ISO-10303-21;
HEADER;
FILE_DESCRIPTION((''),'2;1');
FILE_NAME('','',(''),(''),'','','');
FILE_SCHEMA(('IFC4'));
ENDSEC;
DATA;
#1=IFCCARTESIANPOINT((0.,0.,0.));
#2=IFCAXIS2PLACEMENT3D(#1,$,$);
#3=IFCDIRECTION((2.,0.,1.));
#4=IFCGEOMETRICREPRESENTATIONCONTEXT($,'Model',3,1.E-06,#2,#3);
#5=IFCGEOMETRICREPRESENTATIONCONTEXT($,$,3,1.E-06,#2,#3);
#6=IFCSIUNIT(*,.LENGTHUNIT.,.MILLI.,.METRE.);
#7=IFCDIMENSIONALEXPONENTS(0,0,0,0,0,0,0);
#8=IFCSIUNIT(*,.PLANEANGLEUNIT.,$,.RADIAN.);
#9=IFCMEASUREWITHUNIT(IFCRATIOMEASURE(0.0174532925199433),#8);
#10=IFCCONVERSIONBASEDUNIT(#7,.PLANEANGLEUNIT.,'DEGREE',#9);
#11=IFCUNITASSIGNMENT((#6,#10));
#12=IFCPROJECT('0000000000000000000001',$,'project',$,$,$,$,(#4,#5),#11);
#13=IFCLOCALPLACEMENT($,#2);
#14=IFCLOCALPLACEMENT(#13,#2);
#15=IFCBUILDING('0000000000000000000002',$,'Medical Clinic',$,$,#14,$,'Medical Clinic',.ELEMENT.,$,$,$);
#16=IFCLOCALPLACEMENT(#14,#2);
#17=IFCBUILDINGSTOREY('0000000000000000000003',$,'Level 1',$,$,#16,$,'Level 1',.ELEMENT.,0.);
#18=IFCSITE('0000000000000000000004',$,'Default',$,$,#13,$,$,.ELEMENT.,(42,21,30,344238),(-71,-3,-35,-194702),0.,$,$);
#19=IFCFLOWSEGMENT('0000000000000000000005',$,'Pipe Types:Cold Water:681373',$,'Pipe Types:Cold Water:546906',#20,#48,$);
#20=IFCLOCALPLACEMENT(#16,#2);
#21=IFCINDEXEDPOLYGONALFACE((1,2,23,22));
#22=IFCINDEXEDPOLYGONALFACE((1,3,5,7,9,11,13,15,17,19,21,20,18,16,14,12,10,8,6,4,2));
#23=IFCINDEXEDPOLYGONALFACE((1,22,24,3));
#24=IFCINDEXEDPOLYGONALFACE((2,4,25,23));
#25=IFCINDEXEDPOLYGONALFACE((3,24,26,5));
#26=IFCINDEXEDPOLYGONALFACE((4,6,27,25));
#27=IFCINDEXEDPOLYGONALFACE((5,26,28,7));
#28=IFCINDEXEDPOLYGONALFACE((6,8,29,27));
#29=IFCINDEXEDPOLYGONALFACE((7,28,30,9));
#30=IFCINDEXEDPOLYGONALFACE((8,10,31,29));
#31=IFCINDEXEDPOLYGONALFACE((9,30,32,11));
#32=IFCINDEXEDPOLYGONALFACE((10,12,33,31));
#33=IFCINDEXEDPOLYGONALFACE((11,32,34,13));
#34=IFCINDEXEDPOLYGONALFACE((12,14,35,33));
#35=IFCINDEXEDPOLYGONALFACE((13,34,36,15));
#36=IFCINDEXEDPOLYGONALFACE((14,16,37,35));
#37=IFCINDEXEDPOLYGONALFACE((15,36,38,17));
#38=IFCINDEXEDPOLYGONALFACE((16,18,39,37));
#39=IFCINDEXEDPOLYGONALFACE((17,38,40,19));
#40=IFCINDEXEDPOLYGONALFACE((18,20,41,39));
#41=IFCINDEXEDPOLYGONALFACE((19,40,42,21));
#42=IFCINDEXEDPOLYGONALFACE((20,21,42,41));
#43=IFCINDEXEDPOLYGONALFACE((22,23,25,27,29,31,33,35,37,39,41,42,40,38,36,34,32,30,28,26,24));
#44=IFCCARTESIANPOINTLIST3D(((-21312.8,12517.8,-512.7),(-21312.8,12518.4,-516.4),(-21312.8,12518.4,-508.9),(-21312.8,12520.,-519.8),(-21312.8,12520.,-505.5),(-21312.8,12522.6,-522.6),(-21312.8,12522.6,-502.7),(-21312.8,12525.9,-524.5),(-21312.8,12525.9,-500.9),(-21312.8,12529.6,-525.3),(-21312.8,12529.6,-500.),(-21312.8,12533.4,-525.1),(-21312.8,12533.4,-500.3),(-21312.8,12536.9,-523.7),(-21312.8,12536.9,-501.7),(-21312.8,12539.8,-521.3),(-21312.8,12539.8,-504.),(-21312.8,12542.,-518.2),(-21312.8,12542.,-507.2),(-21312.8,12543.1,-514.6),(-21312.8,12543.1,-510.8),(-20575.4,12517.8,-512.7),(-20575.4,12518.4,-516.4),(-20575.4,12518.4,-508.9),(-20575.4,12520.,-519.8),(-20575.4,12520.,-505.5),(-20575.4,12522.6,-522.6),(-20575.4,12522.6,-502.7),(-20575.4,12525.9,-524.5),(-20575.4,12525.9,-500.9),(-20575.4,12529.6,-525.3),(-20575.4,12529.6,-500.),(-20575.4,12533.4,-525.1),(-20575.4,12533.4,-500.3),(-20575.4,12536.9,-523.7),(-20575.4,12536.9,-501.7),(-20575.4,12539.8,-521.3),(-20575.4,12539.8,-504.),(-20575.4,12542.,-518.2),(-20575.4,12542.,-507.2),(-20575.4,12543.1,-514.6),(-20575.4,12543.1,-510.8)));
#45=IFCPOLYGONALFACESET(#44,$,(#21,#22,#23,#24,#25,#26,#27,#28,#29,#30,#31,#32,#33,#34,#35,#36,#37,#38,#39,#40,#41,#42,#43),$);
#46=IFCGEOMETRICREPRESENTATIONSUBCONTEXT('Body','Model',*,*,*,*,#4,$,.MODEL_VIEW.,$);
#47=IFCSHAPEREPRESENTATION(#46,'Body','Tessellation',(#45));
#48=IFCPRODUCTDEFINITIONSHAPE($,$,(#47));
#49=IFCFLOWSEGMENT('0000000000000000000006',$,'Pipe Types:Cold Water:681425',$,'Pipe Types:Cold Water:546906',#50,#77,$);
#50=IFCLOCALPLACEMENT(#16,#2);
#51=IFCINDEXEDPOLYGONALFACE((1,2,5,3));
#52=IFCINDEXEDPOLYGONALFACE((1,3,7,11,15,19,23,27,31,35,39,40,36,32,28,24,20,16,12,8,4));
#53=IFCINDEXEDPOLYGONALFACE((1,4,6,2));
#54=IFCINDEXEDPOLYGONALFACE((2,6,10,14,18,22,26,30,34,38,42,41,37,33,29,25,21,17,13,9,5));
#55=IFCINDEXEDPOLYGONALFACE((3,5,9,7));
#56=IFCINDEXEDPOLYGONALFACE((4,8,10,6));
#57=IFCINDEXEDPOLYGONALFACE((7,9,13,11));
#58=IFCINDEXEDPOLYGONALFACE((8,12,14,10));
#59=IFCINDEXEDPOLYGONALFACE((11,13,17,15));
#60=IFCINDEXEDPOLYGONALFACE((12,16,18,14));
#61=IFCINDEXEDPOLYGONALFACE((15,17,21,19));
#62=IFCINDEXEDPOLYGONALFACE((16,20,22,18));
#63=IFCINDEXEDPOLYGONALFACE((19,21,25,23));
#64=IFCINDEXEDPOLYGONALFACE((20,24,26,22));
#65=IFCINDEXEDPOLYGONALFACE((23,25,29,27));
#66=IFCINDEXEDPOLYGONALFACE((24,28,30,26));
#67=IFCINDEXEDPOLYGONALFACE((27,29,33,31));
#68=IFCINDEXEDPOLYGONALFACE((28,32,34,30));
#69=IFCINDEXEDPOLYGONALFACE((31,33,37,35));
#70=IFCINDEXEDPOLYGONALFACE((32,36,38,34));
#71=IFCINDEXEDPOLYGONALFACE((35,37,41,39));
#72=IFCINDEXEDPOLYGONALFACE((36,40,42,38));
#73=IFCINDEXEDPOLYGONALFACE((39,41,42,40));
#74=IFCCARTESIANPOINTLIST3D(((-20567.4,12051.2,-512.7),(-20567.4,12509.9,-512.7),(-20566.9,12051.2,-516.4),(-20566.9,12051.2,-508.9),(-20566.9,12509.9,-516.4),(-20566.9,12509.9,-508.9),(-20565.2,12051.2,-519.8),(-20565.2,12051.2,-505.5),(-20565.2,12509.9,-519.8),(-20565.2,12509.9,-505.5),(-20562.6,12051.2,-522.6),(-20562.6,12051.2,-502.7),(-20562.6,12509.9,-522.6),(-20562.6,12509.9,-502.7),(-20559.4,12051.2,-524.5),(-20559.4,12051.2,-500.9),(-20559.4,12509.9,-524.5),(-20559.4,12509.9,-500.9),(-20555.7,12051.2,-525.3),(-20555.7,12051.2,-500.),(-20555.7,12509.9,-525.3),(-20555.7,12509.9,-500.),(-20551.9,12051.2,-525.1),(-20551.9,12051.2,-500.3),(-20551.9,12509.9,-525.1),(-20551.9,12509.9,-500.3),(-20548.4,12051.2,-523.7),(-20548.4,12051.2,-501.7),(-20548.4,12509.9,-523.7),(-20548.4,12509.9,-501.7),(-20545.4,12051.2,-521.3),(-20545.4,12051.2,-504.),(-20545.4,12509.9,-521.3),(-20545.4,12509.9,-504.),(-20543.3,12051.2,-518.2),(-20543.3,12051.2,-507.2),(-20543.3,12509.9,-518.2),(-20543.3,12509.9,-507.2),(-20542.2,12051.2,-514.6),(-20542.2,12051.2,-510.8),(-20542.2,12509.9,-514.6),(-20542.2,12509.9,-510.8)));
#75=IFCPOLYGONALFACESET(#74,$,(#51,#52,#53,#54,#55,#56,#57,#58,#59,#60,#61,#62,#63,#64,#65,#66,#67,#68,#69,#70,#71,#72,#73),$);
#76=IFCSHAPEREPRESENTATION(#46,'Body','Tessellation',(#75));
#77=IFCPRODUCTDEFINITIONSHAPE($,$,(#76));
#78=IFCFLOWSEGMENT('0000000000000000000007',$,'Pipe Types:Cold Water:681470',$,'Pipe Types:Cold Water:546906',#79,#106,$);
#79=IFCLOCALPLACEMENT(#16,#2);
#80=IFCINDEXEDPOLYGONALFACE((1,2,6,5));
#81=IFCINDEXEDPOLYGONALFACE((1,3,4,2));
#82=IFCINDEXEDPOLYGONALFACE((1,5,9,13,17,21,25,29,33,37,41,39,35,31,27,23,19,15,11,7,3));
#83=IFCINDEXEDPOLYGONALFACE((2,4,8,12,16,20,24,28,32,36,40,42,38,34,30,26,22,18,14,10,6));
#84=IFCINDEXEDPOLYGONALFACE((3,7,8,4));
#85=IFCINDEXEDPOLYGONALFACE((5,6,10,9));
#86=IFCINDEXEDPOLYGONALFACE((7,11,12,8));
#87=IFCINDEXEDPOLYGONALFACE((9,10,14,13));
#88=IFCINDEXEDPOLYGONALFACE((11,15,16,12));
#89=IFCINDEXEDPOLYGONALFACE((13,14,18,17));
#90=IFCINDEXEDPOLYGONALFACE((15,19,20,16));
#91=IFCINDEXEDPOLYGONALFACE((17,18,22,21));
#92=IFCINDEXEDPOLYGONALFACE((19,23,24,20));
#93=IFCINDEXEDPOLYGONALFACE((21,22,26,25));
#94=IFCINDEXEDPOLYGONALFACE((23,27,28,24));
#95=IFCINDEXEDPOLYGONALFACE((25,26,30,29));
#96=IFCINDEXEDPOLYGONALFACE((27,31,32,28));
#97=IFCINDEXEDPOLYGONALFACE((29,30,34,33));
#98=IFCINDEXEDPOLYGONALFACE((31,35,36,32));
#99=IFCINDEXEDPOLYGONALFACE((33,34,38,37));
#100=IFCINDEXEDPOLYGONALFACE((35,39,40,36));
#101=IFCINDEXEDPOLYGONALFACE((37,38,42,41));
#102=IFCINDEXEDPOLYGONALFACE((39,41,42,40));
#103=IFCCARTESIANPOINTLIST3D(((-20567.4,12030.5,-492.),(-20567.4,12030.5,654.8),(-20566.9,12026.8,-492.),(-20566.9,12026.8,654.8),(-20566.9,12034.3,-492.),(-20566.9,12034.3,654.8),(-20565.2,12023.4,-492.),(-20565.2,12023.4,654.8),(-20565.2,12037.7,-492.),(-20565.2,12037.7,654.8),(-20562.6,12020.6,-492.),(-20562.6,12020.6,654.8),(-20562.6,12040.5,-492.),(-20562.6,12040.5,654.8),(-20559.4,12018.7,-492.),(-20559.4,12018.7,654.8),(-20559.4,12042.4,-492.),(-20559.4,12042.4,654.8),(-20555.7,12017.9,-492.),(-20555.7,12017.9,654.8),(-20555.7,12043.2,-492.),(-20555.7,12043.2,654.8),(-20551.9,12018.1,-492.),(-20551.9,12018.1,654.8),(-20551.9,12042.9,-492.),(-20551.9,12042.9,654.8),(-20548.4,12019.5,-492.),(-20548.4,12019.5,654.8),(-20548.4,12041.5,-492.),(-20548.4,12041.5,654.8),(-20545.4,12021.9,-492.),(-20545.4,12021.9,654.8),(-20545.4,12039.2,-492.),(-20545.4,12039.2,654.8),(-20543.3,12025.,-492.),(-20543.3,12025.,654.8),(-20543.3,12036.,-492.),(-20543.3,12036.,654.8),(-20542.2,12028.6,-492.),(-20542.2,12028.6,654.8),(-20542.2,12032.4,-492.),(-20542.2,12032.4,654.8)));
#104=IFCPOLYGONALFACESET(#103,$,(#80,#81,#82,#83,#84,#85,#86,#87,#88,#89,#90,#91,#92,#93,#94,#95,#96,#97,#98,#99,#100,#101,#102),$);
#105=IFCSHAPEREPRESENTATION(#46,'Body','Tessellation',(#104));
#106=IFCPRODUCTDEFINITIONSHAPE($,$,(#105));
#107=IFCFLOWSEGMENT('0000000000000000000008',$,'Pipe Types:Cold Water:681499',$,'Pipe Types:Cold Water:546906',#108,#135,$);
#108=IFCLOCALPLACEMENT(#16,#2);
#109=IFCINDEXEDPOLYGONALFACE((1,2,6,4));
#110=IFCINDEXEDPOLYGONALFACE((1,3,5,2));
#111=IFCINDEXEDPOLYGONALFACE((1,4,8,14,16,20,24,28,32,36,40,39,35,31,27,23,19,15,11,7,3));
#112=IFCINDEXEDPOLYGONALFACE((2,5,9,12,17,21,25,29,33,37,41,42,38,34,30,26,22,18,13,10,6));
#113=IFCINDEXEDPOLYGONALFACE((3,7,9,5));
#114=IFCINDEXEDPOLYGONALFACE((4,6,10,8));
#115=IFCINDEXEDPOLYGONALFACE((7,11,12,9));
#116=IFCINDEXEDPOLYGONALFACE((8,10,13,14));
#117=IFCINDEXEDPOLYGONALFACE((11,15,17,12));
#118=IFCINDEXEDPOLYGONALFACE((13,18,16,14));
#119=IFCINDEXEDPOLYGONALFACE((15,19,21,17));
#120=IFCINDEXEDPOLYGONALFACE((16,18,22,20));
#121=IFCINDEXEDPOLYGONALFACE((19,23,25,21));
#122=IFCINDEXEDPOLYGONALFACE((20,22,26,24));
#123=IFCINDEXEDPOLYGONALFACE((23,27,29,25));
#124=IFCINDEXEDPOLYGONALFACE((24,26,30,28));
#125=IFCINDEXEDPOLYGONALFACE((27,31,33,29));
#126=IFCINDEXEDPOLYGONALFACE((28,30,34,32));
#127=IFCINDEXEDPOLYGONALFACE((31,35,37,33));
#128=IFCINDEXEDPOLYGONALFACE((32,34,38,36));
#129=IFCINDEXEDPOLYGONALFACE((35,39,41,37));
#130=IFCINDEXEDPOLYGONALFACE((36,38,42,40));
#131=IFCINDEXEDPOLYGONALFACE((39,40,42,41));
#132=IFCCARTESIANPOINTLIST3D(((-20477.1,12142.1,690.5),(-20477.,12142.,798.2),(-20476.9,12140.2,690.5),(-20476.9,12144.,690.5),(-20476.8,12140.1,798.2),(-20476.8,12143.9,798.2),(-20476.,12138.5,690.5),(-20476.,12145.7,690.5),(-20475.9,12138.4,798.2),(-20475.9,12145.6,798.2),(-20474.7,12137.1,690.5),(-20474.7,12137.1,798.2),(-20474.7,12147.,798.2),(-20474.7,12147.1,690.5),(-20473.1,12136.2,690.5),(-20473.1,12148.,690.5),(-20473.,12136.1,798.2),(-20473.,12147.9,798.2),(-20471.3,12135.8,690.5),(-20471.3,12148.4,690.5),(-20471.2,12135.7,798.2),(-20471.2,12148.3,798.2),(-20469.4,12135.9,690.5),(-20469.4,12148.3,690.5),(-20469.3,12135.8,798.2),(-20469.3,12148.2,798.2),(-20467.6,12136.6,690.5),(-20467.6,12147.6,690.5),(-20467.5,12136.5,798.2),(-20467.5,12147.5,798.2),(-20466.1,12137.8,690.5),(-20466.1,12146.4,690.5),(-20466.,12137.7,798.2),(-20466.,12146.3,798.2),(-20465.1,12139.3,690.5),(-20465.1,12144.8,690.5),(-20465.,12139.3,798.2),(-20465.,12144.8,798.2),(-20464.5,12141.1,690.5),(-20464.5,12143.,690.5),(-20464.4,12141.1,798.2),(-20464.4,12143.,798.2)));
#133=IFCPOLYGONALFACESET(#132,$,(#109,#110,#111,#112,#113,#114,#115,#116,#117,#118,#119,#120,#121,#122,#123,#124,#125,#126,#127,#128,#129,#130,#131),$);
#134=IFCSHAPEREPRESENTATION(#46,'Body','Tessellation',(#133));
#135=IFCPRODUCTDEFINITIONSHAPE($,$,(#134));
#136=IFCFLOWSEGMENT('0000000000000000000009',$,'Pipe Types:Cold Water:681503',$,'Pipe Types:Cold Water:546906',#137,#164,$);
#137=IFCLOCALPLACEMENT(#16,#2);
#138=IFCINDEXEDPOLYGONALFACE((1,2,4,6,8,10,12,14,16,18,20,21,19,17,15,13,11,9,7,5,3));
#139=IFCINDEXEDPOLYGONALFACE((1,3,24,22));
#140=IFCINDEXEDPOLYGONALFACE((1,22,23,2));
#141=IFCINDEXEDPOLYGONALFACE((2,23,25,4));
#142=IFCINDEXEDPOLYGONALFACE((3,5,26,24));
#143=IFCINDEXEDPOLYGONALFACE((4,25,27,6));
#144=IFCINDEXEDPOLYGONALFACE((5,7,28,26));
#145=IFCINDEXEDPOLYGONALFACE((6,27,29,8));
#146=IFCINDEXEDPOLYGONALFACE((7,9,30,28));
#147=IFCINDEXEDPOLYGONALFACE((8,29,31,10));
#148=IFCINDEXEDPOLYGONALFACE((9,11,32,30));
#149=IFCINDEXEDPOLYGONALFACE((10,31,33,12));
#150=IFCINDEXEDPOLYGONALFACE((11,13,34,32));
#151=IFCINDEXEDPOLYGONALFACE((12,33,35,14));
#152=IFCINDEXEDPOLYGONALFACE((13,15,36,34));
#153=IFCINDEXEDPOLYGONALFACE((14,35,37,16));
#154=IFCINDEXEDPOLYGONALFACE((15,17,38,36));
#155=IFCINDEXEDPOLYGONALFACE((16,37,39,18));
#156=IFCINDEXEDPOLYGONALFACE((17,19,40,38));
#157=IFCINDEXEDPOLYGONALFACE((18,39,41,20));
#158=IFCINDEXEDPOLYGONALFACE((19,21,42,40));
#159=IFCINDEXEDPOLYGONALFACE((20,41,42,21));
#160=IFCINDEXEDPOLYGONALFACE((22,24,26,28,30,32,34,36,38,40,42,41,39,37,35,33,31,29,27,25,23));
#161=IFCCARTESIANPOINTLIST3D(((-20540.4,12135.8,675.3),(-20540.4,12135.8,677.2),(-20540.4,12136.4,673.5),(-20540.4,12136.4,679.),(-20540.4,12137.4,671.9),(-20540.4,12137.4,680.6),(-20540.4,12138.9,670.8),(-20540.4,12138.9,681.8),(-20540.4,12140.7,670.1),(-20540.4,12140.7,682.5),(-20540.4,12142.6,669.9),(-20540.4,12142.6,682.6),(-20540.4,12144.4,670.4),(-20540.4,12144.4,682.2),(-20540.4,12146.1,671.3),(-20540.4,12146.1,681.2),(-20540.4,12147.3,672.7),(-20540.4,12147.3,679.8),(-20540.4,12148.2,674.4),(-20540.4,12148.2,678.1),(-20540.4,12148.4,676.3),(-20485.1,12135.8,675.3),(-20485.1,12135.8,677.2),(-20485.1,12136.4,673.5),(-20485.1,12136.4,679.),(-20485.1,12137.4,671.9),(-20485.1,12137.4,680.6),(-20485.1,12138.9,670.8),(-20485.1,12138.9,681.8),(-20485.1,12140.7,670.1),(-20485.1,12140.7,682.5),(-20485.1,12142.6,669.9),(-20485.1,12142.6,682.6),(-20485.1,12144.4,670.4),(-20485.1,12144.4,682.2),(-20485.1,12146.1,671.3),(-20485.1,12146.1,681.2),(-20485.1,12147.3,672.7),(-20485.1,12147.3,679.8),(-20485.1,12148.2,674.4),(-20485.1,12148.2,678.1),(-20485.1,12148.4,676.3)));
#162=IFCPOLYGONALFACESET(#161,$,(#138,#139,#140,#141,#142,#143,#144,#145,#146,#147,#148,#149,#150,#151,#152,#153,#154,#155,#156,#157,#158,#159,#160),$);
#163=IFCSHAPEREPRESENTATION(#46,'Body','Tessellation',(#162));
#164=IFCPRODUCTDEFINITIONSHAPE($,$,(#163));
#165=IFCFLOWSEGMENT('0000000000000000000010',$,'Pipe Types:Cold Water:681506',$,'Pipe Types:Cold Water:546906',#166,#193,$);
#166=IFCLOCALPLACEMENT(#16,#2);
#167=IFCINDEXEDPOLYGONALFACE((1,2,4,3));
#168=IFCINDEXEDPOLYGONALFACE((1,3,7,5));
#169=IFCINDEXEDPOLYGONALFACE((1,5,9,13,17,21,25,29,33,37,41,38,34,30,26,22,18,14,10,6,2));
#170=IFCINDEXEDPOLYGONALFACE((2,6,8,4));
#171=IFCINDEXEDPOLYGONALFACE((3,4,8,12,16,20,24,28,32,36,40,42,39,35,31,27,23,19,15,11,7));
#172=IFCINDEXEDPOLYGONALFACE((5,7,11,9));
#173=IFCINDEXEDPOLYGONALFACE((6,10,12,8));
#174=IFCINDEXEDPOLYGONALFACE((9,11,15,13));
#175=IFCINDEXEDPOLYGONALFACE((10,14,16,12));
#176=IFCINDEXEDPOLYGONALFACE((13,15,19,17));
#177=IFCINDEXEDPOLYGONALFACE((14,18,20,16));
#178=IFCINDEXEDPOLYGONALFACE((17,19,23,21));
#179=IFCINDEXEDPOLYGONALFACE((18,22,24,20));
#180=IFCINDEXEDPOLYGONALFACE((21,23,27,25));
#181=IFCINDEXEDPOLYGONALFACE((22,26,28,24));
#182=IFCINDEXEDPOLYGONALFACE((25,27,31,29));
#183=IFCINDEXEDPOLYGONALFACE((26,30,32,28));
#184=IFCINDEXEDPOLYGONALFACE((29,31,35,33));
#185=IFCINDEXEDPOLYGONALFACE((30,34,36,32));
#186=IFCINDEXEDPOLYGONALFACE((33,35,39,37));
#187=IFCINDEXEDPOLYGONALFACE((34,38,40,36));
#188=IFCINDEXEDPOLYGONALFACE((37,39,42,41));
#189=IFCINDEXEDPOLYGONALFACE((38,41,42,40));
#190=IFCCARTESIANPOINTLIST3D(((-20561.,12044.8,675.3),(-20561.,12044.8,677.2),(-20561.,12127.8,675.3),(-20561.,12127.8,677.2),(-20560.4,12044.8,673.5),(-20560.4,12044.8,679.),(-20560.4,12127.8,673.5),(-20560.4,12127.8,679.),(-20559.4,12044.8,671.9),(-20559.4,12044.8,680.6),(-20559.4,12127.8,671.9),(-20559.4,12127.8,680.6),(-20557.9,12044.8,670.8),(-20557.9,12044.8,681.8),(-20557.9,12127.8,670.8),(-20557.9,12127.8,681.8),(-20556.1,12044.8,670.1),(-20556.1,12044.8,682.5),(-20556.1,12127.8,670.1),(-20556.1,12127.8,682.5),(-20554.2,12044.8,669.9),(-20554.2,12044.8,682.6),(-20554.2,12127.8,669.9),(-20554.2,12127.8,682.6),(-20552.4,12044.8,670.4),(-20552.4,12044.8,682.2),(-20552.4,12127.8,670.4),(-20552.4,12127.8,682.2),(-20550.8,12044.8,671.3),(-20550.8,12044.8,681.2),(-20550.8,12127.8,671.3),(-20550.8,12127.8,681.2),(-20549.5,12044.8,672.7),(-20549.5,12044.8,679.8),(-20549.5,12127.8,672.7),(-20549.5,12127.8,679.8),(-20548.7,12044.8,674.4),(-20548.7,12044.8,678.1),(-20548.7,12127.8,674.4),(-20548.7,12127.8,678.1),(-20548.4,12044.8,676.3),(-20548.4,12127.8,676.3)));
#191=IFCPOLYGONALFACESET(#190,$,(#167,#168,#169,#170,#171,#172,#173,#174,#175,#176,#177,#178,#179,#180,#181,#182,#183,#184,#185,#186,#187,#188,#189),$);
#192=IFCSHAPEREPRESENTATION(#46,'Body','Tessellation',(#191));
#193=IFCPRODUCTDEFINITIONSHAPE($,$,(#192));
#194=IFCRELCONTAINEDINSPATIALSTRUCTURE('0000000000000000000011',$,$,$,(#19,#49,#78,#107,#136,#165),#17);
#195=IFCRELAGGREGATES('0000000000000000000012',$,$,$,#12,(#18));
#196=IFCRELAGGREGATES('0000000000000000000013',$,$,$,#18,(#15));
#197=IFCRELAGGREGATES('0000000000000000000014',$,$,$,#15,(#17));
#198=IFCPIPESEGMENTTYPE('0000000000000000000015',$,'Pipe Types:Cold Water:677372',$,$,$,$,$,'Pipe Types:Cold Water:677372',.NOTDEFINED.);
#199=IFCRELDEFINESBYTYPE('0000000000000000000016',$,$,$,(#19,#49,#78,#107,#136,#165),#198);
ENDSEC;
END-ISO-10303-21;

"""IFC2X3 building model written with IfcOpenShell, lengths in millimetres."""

from ifc_helpers import new_model, entity, si_unit, converted_unit, direction, frame, frame_2d, origin, origin_2d_with_axis, place, context, subcontext, project, spatial, circle, extrude, type_object, element, save


model = new_model("IFC2X3")

# Units and contexts
model_context = context("Model", 3, precision=1e-06, world=origin(), true_north=direction((2.0, 0.0, 1.0)))
context_of_model = context(None, 3, precision=1e-06, world=origin(), true_north=direction((2.0, 0.0, 1.0)))
body_context = subcontext(model_context, "Body", "Model", "MODEL_VIEW")
ifc_project = project(units=[si_unit("LENGTHUNIT", "METRE", prefix="MILLI"), converted_unit("PLANEANGLEUNIT", "DEGREE", entity("IfcRatioMeasure", 0.0174532925199433), si_unit("PLANEANGLEUNIT", "RADIAN"), dimensions=[0, 0, 0, 0, 0, 0, 0])], contexts=[model_context, context_of_model])

# Site, building, storey
site_placement = place(None, origin())
site = spatial("IfcSite", under=ifc_project, at=site_placement, Name="Default", CompositionType="ELEMENT", RefLatitude=(42, 21, 30, 344238), RefLongitude=(-71, -3, -35, -194702), RefElevation=0.0)
building_placement = place(site_placement, origin())
building = spatial("IfcBuilding", under=site, at=building_placement, Name="Medical Clinic", LongName="Medical Clinic", CompositionType="ELEMENT")
storey_placement = place(building_placement, origin())
storey = spatial("IfcBuildingStorey", under=building, at=storey_placement, Name="Level 1", LongName="Level 1", CompositionType="ELEMENT", Elevation=0.0)

# Flow segments
pipe_segment_type_1 = type_object("IfcPipeSegmentType", Name="Pipe Types:Cold Water:677372", ElementType="Pipe Types:Cold Water:677372", PredefinedType="NOTDEFINED")
flow_segment_1_placement = place(storey_placement, origin())
element("IfcFlowSegment", 1, at=flow_segment_1_placement, inside=storey, type_object=pipe_segment_type_1, Name="Pipe Types:Cold Water:681373", ObjectType="Pipe Types:Cold Water:546906", context=body_context, shape_type="SweptSolid", body=[
    extrude(circle(Radius=12.7, at=origin_2d_with_axis()), frame((-21312.8, 12530.5, -512.7), z_axis=(1.0, 0.0, 0.0), x_axis=(0.0, -1.0, 0.0)), (0.0, 0.0, 1.0), 737.5),
])
flow_segment_2_placement = place(storey_placement, origin())
element("IfcFlowSegment", 2, at=flow_segment_2_placement, inside=storey, type_object=pipe_segment_type_1, Name="Pipe Types:Cold Water:681425", ObjectType="Pipe Types:Cold Water:546906", context=body_context, shape_type="SweptSolid", body=[
    extrude(circle(Radius=12.7, at=origin_2d_with_axis()), frame((-20554.7, 12051.2, -512.7), z_axis=(0.0, 1.0, 0.0), x_axis=(-1.0, 0.0, 0.0)), (0.0, 0.0, 1.0), 458.7),
])
flow_segment_3_placement = place(storey_placement, origin())
element("IfcFlowSegment", 3, at=flow_segment_3_placement, inside=storey, type_object=pipe_segment_type_1, Name="Pipe Types:Cold Water:681470", ObjectType="Pipe Types:Cold Water:546906", context=body_context, shape_type="SweptSolid", body=[
    extrude(circle(Radius=12.7, at=frame_2d((0.0, 0.0), x_axis=(1.0, 0.0))), frame((-20554.7, 12030.5, -492.0), z_axis=(0.0, 0.0, 1.0), x_axis=(-1.0, 0.0, 0.0)), (0.0, 0.0, 1.0), 1146.9),
])
flow_segment_4_placement = place(storey_placement, origin())
element("IfcFlowSegment", 4, at=flow_segment_4_placement, inside=storey, type_object=pipe_segment_type_1, Name="Pipe Types:Cold Water:681499", ObjectType="Pipe Types:Cold Water:546906", context=body_context, shape_type="SweptSolid", body=[
    extrude(circle(Radius=6.3, at=origin_2d_with_axis()), frame((-20470.7, 12142.0, 798.2), z_axis=(-0.000816, 0.000674, -0.999999), x_axis=(-1.0, 0.0, 0.000816)), (0.0, 0.0, 1.0), 107.7),
])
flow_segment_5_placement = place(storey_placement, origin())
element("IfcFlowSegment", 5, at=flow_segment_5_placement, inside=storey, type_object=pipe_segment_type_1, Name="Pipe Types:Cold Water:681503", ObjectType="Pipe Types:Cold Water:546906", context=body_context, shape_type="SweptSolid", body=[
    extrude(circle(Radius=6.3, at=origin_2d_with_axis()), frame((-20540.4, 12142.1, 676.3), z_axis=(1.0, 0.0, 0.0), x_axis=(0.0, 1.0, 0.0)), (0.0, 0.0, 1.0), 55.4),
])
flow_segment_6_placement = place(storey_placement, origin())
element("IfcFlowSegment", 6, at=flow_segment_6_placement, inside=storey, type_object=pipe_segment_type_1, Name="Pipe Types:Cold Water:681506", ObjectType="Pipe Types:Cold Water:546906", context=body_context, shape_type="SweptSolid", body=[
    extrude(circle(Radius=6.3, at=origin_2d_with_axis()), frame((-20554.7, 12044.8, 676.3), z_axis=(0.0, 1.0, 0.0), x_axis=(1.0, 0.0, 0.0)), (0.0, 0.0, 1.0), 83.0),
])

save(model, "model.ifc")
